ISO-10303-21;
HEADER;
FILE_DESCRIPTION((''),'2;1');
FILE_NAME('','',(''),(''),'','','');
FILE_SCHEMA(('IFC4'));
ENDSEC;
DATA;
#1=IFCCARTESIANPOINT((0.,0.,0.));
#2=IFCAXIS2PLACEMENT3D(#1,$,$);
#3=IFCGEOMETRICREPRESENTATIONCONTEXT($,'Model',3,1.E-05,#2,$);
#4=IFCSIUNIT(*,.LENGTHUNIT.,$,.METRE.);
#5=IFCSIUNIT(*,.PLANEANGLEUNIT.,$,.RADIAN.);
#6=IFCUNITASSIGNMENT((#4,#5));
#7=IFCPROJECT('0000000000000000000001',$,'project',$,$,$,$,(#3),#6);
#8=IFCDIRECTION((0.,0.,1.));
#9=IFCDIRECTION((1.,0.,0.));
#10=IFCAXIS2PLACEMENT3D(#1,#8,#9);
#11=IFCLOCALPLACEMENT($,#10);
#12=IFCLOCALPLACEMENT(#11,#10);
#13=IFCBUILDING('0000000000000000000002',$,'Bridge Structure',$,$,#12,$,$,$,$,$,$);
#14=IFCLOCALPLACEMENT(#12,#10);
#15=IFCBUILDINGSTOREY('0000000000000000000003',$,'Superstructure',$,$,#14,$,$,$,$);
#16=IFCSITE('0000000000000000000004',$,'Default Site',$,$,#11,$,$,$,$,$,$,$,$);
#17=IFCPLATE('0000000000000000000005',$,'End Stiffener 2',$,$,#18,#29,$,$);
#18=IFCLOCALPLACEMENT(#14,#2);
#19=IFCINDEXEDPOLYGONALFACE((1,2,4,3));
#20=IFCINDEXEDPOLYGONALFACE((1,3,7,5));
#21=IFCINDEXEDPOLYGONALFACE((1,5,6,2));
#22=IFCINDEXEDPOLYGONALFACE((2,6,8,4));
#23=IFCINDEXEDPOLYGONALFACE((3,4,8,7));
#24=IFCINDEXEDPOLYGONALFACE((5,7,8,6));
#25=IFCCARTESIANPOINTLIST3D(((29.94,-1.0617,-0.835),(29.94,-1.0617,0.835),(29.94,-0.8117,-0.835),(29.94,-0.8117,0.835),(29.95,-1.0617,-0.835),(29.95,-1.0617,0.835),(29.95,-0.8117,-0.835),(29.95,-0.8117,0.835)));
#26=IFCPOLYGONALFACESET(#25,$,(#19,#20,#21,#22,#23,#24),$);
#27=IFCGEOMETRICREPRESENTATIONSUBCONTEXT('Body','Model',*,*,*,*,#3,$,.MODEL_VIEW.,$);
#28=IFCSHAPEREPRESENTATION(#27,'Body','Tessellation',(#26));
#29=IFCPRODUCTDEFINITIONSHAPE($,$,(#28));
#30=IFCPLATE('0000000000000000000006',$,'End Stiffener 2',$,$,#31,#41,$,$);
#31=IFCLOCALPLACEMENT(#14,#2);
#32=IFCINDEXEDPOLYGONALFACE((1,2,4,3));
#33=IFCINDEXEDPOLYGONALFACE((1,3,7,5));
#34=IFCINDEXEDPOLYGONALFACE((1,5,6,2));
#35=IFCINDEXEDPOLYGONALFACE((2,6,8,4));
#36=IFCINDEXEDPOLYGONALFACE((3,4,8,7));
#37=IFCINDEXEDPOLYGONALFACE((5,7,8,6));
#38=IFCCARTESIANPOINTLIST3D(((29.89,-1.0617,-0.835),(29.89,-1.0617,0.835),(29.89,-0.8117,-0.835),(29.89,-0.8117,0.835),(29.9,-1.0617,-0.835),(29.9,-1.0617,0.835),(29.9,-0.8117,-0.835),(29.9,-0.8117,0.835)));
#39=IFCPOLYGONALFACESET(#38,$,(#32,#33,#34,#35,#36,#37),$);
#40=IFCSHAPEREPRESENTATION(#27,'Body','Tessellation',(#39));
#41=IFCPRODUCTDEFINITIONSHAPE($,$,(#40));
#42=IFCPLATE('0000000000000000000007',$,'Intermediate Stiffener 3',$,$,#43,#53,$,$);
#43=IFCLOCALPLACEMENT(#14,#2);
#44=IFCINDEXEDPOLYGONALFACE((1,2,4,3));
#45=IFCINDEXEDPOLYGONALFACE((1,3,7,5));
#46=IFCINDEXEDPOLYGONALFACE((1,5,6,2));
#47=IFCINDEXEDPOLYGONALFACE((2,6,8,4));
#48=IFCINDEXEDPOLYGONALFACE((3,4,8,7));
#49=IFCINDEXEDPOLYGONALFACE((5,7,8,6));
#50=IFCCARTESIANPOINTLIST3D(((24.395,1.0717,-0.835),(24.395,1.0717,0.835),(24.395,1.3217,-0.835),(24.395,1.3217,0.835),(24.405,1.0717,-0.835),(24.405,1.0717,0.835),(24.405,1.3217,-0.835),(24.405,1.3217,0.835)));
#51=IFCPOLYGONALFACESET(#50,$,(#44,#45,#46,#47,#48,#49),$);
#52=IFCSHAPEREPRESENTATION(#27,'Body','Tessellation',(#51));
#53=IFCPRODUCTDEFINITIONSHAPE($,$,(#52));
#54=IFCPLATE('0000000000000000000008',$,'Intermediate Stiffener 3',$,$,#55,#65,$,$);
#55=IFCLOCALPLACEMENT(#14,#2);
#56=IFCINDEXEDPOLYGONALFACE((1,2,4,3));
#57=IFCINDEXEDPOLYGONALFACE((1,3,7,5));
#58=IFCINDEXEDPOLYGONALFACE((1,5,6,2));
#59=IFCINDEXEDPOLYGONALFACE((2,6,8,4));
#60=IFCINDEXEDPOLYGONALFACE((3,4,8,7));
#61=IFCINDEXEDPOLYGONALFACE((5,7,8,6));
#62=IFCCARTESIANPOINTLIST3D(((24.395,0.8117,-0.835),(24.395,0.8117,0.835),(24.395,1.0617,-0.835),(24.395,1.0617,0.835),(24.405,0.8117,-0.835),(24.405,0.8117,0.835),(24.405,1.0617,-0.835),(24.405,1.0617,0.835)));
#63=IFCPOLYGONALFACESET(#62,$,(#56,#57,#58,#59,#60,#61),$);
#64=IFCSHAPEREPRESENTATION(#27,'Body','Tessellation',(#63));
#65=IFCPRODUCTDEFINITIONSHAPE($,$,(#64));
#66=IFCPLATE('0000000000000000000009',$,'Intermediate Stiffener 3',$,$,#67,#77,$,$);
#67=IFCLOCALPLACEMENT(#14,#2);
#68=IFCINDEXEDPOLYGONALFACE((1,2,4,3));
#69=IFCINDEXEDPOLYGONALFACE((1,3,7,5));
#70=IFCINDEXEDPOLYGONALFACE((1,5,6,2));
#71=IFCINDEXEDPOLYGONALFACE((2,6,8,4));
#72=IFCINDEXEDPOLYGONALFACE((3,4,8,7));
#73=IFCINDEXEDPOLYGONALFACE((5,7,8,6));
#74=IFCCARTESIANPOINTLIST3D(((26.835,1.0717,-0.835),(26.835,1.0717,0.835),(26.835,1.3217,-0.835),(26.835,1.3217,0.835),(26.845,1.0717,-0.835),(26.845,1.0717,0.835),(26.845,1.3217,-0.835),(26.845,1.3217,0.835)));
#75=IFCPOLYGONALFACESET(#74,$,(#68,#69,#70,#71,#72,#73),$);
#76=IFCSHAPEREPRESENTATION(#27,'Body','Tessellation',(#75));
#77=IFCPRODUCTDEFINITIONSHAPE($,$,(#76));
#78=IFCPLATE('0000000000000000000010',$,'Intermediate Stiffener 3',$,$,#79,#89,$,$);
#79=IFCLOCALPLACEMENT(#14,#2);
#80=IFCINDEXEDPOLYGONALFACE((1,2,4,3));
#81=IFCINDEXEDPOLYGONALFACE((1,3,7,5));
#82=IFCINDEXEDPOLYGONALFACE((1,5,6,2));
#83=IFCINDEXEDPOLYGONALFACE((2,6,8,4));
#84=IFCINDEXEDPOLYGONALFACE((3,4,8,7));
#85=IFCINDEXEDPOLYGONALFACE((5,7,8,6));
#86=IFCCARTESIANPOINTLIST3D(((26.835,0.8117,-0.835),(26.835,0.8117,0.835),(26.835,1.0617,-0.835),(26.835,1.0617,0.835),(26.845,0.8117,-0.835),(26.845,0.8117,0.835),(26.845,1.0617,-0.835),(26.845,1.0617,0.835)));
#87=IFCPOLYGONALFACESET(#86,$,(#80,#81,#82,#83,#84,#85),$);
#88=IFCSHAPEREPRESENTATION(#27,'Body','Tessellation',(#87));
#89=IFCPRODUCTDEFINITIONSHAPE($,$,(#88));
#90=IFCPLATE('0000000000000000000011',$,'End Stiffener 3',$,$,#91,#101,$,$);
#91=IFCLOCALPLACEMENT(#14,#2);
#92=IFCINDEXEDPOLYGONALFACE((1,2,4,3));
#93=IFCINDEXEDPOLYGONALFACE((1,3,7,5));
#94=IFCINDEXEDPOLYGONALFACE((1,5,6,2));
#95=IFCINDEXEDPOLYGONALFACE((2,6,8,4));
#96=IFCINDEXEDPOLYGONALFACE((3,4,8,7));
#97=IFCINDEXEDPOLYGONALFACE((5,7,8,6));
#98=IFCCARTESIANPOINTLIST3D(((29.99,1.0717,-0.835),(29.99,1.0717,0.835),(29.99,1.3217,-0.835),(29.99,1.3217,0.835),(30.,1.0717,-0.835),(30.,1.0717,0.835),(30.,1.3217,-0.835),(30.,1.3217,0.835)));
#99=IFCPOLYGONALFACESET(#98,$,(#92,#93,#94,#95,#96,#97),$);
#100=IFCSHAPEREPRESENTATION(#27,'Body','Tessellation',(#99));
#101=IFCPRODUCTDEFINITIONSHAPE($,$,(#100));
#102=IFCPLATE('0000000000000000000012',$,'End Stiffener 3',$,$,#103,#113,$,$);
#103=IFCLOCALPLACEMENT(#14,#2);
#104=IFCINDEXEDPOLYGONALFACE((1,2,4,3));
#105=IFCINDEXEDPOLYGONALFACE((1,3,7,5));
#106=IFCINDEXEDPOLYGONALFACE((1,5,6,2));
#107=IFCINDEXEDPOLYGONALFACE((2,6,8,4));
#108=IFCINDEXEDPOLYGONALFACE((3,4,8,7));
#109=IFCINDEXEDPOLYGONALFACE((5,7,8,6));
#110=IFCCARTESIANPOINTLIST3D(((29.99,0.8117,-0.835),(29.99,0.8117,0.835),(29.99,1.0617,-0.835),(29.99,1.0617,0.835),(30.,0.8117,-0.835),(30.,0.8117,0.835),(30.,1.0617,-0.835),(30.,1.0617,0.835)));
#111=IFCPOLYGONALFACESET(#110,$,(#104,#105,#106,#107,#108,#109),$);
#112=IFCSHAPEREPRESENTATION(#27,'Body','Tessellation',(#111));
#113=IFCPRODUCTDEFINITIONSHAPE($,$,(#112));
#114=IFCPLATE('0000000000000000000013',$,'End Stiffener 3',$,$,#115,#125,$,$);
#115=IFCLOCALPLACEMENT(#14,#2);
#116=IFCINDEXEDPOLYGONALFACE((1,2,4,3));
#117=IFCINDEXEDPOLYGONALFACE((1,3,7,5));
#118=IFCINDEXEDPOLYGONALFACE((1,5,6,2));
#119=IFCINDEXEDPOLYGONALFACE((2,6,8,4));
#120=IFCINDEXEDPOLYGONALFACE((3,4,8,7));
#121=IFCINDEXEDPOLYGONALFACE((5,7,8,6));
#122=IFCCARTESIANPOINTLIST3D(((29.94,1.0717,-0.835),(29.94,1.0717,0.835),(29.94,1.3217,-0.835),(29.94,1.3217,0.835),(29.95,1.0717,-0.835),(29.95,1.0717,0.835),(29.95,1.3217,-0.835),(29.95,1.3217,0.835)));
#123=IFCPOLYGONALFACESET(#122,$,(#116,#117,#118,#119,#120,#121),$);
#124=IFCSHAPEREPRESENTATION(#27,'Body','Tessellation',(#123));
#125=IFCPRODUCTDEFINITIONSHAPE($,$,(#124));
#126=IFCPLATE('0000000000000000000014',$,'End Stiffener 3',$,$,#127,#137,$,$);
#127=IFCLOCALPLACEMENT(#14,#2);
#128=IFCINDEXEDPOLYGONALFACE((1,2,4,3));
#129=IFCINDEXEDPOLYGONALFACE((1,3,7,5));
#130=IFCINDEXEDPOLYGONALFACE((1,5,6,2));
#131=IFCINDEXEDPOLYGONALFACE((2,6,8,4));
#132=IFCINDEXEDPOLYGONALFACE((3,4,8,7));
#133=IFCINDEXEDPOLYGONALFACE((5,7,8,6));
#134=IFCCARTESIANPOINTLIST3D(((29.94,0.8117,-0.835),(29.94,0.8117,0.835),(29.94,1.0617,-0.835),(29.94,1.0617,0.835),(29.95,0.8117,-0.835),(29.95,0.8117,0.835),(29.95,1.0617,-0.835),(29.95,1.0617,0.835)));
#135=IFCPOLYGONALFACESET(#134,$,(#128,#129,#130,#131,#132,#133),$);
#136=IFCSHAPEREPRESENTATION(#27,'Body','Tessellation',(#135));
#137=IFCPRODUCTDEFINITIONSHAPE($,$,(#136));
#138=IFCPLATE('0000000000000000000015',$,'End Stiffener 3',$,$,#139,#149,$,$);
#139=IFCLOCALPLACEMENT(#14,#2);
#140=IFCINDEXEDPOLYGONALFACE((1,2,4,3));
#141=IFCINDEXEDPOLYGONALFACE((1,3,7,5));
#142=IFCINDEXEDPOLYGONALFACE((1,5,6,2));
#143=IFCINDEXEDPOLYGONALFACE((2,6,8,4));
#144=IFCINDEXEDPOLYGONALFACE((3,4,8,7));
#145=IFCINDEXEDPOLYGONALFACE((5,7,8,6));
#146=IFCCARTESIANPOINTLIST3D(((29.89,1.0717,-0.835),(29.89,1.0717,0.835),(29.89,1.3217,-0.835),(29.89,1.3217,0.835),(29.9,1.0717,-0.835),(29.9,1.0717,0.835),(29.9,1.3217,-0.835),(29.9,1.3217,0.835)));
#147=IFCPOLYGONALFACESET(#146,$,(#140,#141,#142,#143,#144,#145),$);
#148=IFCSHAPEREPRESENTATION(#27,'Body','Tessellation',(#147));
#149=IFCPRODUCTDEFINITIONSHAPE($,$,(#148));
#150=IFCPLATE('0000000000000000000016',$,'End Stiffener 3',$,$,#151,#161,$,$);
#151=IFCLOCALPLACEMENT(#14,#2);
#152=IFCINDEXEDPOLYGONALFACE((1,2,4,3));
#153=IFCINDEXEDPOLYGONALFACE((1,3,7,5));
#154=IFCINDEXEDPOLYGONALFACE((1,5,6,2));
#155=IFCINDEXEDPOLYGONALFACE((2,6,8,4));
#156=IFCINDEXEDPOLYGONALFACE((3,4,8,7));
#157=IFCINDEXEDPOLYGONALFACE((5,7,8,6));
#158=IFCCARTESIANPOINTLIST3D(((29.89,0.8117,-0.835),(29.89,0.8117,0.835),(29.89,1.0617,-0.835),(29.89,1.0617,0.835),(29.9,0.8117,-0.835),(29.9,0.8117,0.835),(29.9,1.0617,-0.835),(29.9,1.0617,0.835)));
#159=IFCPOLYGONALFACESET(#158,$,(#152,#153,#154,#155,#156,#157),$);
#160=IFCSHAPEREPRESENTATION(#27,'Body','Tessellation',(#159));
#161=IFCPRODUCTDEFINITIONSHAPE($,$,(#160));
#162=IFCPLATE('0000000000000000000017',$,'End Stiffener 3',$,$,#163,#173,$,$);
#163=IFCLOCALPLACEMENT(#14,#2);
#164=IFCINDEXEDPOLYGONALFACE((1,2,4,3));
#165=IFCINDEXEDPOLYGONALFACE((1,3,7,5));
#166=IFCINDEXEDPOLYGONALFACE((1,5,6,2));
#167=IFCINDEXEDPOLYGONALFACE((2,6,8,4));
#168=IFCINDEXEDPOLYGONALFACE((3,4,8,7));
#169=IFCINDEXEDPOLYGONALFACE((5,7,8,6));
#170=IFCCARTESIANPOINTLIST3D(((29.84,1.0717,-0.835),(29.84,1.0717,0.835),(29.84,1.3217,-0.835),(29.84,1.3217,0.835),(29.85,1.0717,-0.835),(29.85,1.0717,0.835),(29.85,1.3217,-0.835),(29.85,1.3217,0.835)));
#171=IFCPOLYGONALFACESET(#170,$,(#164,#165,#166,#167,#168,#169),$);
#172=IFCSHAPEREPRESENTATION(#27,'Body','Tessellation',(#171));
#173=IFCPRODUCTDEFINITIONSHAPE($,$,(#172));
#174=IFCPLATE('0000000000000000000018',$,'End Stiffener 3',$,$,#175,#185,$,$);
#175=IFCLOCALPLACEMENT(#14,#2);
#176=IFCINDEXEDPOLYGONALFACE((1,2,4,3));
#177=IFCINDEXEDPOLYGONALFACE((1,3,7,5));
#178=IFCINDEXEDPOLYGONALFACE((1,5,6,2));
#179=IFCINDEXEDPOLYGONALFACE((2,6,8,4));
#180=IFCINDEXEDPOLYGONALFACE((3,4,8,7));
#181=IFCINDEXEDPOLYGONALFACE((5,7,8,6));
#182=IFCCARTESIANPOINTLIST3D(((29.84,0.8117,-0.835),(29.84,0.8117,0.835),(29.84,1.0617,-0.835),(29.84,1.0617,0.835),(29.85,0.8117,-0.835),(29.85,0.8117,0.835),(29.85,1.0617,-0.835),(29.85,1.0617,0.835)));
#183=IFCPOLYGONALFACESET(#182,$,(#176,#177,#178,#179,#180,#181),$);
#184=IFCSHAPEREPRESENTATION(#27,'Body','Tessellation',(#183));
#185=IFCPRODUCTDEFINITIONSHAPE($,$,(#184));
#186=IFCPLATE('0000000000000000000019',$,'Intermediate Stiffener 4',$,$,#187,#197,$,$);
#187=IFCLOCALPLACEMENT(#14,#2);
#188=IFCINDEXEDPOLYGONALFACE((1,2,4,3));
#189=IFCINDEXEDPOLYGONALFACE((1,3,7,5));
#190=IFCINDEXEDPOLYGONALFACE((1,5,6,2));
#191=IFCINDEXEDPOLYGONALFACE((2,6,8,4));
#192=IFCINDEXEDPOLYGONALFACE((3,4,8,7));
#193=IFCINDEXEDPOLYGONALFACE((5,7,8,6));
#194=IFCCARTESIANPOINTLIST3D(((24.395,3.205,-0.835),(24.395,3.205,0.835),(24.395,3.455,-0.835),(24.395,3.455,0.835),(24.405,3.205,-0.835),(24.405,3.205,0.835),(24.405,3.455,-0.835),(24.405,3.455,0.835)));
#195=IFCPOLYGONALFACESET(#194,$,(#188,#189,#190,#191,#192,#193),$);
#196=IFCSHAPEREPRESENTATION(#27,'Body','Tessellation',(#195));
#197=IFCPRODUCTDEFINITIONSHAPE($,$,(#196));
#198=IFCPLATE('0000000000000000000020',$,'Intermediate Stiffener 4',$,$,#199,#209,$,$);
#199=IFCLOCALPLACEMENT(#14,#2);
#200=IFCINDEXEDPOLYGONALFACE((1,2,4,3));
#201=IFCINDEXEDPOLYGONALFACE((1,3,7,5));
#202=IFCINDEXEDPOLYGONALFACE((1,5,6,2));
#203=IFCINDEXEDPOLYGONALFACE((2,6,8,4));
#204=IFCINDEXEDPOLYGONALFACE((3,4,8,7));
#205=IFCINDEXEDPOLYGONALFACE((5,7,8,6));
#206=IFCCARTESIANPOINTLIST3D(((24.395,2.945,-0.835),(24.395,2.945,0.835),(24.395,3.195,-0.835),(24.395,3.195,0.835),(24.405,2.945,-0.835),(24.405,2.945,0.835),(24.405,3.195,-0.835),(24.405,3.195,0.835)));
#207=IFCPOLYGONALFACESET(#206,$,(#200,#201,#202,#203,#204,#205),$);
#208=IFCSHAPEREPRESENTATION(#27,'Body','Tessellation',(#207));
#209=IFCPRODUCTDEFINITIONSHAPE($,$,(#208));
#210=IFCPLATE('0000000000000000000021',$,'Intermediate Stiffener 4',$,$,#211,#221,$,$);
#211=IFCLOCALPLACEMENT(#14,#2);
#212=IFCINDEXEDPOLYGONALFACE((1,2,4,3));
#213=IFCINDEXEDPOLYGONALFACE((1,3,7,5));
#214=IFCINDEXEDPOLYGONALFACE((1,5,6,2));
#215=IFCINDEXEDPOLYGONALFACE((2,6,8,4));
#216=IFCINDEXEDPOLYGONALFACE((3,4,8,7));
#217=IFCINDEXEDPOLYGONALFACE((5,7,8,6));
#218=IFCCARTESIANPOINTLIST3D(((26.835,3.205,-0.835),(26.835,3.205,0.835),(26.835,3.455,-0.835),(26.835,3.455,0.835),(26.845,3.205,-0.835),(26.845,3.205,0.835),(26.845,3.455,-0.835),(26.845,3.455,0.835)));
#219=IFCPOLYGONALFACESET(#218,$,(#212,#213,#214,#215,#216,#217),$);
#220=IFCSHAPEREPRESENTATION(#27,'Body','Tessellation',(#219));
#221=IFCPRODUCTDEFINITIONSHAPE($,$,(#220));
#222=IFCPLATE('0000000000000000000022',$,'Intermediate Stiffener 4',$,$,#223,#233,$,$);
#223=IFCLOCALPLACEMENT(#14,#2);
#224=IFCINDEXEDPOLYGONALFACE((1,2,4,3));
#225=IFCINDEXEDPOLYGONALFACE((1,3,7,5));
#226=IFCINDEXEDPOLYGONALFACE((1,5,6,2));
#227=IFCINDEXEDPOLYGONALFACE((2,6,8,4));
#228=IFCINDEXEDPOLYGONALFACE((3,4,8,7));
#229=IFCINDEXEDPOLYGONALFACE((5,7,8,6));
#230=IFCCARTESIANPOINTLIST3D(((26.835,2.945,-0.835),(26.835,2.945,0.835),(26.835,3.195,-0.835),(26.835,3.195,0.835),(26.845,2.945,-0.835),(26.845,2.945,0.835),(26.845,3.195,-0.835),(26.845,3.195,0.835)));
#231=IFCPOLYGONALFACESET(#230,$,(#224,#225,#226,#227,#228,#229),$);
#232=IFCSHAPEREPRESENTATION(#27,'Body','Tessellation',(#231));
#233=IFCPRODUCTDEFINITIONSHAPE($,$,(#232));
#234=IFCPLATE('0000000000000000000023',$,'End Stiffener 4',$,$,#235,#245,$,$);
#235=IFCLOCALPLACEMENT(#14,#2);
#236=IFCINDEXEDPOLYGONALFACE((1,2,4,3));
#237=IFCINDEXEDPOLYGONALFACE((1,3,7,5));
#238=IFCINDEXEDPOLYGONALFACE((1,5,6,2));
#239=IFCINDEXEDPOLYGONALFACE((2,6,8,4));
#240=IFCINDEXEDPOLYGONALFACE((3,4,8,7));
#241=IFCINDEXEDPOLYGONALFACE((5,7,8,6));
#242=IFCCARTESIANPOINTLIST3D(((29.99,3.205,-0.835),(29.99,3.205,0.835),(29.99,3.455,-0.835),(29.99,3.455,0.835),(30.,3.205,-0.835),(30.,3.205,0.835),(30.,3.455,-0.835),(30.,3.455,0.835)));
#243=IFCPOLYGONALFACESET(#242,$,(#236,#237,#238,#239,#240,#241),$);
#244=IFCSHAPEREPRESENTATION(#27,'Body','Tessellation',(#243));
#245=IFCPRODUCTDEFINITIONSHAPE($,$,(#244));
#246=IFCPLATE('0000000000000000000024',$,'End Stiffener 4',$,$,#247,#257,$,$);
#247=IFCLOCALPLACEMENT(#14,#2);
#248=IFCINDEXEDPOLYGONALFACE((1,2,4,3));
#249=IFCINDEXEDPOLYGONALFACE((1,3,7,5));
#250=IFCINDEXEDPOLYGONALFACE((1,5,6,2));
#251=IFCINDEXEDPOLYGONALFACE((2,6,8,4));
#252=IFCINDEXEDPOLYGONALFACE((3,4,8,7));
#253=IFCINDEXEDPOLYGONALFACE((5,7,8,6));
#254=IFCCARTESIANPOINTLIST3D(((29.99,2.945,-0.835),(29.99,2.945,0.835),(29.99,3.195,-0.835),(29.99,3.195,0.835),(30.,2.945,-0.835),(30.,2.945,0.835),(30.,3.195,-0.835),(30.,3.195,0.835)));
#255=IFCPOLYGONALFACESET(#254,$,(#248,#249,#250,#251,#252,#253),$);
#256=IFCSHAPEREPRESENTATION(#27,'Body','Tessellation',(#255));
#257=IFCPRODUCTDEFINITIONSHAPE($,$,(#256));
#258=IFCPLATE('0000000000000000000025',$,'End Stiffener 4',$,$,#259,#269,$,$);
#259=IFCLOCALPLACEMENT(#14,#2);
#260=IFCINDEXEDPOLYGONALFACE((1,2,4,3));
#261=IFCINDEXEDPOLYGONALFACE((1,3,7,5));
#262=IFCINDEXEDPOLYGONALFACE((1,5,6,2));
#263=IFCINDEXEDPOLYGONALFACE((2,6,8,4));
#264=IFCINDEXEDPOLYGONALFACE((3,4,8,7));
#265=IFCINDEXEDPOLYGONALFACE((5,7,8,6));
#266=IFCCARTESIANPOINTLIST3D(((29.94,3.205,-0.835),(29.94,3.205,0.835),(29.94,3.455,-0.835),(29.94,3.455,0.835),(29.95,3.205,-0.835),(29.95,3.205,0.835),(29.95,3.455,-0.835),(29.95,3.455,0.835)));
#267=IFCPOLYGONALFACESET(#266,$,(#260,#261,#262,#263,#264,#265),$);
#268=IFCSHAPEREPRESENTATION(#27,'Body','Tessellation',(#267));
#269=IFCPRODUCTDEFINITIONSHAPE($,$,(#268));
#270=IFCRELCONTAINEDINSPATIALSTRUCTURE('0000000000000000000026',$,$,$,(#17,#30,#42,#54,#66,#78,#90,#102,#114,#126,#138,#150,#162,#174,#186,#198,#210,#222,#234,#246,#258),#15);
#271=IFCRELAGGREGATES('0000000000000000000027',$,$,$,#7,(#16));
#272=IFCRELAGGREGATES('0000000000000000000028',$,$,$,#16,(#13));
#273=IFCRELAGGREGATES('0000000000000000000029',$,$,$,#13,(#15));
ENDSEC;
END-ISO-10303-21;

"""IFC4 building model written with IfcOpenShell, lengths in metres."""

from ifc_helpers import new_model, si_unit, frame, origin, origin_with_axes, origin_2d_with_axis, place, context, subcontext, project, spatial, rectangle, extrude, element, save


model = new_model("IFC4")

# Units and contexts
model_context = context("Model", 3, precision=1e-05, world=origin())
body_context = subcontext(model_context, "Body", "Model", "MODEL_VIEW")
ifc_project = project(units=[si_unit("LENGTHUNIT", "METRE"), si_unit("PLANEANGLEUNIT", "RADIAN")], contexts=[model_context])

# Site, building, storey
site_placement = place(None, origin_with_axes())
site = spatial("IfcSite", under=ifc_project, at=site_placement, Name="Default Site")
building_placement = place(site_placement, origin_with_axes())
building = spatial("IfcBuilding", under=site, at=building_placement, Name="Bridge Structure")
storey_placement = place(building_placement, origin_with_axes())
storey = spatial("IfcBuildingStorey", under=building, at=storey_placement, Name="Superstructure")

# Plates
for number, where, z_axis, x_axis, name in (
    (1, (29.945, -0.9367, -0.835), (0.0, 0.0, 1.0), (1.0, 0.0, 0.0), "End Stiffener 2"),
    (2, (29.895, -0.9367, -0.835), (0.0, 0.0, 1.0), (1.0, 0.0, 0.0), "End Stiffener 2"),
    (3, (24.4, 1.1967, -0.835), (0.0, 0.0, 1.0), (1.0, 0.0, 0.0), "Intermediate Stiffener 3"),
    (4, (24.4, 0.9367, -0.835), (0.0, 0.0, 1.0), (1.0, 0.0, 0.0), "Intermediate Stiffener 3"),
    (5, (26.84, 1.1967, -0.835), (0.0, 0.0, 1.0), (1.0, 0.0, 0.0), "Intermediate Stiffener 3"),
    (6, (26.84, 0.9367, -0.835), (0.0, 0.0, 1.0), (1.0, 0.0, 0.0), "Intermediate Stiffener 3"),
    (7, (29.995, 1.1967, -0.835), (0.0, 0.0, 1.0), (1.0, 0.0, 0.0), "End Stiffener 3"),
    (8, (29.995, 0.9367, -0.835), (0.0, 0.0, 1.0), (1.0, 0.0, 0.0), "End Stiffener 3"),
    (9, (29.945, 1.1967, -0.835), (0.0, 0.0, 1.0), (1.0, 0.0, 0.0), "End Stiffener 3"),
    (10, (29.945, 0.9367, -0.835), (0.0, 0.0, 1.0), (1.0, 0.0, 0.0), "End Stiffener 3"),
    (11, (29.895, 1.1967, -0.835), (0.0, 0.0, 1.0), (1.0, 0.0, 0.0), "End Stiffener 3"),
    (12, (29.895, 0.9367, -0.835), (0.0, 0.0, 1.0), (1.0, 0.0, 0.0), "End Stiffener 3"),
    (13, (29.845, 1.1967, -0.835), (0.0, 0.0, 1.0), (1.0, 0.0, 0.0), "End Stiffener 3"),
    (14, (29.845, 0.9367, -0.835), (0.0, 0.0, 1.0), (1.0, 0.0, 0.0), "End Stiffener 3"),
    (15, (24.4, 3.33, -0.835), (0.0, 0.0, 1.0), (1.0, 0.0, 0.0), "Intermediate Stiffener 4"),
    (16, (24.4, 3.07, -0.835), (0.0, 0.0, 1.0), (1.0, 0.0, 0.0), "Intermediate Stiffener 4"),
    (17, (26.84, 3.33, -0.835), (0.0, 0.0, 1.0), (1.0, 0.0, 0.0), "Intermediate Stiffener 4"),
    (18, (26.84, 3.07, -0.835), (0.0, 0.0, 1.0), (1.0, 0.0, 0.0), "Intermediate Stiffener 4"),
    (19, (29.995, 3.33, -0.835), (0.0, 0.0, 1.0), (1.0, 0.0, 0.0), "End Stiffener 4"),
    (20, (29.995, 3.07, -0.835), (0.0, 0.0, 1.0), (1.0, 0.0, 0.0), "End Stiffener 4"),
    (21, (29.945, 3.33, -0.835), (0.0, 0.0, 1.0), (1.0, 0.0, 0.0), "End Stiffener 4"),
):
    element("IfcPlate", number, at=place(storey_placement, frame(where, z_axis=z_axis, x_axis=x_axis)), inside=storey, Name=name, context=body_context, shape_type="SweptSolid", body=[
        extrude(rectangle(XDim=0.01, YDim=0.25, at=origin_2d_with_axis()), origin_with_axes(), (0.0, 0.0, 1.0), 1.67),
    ])

save(model, "model.ifc")
